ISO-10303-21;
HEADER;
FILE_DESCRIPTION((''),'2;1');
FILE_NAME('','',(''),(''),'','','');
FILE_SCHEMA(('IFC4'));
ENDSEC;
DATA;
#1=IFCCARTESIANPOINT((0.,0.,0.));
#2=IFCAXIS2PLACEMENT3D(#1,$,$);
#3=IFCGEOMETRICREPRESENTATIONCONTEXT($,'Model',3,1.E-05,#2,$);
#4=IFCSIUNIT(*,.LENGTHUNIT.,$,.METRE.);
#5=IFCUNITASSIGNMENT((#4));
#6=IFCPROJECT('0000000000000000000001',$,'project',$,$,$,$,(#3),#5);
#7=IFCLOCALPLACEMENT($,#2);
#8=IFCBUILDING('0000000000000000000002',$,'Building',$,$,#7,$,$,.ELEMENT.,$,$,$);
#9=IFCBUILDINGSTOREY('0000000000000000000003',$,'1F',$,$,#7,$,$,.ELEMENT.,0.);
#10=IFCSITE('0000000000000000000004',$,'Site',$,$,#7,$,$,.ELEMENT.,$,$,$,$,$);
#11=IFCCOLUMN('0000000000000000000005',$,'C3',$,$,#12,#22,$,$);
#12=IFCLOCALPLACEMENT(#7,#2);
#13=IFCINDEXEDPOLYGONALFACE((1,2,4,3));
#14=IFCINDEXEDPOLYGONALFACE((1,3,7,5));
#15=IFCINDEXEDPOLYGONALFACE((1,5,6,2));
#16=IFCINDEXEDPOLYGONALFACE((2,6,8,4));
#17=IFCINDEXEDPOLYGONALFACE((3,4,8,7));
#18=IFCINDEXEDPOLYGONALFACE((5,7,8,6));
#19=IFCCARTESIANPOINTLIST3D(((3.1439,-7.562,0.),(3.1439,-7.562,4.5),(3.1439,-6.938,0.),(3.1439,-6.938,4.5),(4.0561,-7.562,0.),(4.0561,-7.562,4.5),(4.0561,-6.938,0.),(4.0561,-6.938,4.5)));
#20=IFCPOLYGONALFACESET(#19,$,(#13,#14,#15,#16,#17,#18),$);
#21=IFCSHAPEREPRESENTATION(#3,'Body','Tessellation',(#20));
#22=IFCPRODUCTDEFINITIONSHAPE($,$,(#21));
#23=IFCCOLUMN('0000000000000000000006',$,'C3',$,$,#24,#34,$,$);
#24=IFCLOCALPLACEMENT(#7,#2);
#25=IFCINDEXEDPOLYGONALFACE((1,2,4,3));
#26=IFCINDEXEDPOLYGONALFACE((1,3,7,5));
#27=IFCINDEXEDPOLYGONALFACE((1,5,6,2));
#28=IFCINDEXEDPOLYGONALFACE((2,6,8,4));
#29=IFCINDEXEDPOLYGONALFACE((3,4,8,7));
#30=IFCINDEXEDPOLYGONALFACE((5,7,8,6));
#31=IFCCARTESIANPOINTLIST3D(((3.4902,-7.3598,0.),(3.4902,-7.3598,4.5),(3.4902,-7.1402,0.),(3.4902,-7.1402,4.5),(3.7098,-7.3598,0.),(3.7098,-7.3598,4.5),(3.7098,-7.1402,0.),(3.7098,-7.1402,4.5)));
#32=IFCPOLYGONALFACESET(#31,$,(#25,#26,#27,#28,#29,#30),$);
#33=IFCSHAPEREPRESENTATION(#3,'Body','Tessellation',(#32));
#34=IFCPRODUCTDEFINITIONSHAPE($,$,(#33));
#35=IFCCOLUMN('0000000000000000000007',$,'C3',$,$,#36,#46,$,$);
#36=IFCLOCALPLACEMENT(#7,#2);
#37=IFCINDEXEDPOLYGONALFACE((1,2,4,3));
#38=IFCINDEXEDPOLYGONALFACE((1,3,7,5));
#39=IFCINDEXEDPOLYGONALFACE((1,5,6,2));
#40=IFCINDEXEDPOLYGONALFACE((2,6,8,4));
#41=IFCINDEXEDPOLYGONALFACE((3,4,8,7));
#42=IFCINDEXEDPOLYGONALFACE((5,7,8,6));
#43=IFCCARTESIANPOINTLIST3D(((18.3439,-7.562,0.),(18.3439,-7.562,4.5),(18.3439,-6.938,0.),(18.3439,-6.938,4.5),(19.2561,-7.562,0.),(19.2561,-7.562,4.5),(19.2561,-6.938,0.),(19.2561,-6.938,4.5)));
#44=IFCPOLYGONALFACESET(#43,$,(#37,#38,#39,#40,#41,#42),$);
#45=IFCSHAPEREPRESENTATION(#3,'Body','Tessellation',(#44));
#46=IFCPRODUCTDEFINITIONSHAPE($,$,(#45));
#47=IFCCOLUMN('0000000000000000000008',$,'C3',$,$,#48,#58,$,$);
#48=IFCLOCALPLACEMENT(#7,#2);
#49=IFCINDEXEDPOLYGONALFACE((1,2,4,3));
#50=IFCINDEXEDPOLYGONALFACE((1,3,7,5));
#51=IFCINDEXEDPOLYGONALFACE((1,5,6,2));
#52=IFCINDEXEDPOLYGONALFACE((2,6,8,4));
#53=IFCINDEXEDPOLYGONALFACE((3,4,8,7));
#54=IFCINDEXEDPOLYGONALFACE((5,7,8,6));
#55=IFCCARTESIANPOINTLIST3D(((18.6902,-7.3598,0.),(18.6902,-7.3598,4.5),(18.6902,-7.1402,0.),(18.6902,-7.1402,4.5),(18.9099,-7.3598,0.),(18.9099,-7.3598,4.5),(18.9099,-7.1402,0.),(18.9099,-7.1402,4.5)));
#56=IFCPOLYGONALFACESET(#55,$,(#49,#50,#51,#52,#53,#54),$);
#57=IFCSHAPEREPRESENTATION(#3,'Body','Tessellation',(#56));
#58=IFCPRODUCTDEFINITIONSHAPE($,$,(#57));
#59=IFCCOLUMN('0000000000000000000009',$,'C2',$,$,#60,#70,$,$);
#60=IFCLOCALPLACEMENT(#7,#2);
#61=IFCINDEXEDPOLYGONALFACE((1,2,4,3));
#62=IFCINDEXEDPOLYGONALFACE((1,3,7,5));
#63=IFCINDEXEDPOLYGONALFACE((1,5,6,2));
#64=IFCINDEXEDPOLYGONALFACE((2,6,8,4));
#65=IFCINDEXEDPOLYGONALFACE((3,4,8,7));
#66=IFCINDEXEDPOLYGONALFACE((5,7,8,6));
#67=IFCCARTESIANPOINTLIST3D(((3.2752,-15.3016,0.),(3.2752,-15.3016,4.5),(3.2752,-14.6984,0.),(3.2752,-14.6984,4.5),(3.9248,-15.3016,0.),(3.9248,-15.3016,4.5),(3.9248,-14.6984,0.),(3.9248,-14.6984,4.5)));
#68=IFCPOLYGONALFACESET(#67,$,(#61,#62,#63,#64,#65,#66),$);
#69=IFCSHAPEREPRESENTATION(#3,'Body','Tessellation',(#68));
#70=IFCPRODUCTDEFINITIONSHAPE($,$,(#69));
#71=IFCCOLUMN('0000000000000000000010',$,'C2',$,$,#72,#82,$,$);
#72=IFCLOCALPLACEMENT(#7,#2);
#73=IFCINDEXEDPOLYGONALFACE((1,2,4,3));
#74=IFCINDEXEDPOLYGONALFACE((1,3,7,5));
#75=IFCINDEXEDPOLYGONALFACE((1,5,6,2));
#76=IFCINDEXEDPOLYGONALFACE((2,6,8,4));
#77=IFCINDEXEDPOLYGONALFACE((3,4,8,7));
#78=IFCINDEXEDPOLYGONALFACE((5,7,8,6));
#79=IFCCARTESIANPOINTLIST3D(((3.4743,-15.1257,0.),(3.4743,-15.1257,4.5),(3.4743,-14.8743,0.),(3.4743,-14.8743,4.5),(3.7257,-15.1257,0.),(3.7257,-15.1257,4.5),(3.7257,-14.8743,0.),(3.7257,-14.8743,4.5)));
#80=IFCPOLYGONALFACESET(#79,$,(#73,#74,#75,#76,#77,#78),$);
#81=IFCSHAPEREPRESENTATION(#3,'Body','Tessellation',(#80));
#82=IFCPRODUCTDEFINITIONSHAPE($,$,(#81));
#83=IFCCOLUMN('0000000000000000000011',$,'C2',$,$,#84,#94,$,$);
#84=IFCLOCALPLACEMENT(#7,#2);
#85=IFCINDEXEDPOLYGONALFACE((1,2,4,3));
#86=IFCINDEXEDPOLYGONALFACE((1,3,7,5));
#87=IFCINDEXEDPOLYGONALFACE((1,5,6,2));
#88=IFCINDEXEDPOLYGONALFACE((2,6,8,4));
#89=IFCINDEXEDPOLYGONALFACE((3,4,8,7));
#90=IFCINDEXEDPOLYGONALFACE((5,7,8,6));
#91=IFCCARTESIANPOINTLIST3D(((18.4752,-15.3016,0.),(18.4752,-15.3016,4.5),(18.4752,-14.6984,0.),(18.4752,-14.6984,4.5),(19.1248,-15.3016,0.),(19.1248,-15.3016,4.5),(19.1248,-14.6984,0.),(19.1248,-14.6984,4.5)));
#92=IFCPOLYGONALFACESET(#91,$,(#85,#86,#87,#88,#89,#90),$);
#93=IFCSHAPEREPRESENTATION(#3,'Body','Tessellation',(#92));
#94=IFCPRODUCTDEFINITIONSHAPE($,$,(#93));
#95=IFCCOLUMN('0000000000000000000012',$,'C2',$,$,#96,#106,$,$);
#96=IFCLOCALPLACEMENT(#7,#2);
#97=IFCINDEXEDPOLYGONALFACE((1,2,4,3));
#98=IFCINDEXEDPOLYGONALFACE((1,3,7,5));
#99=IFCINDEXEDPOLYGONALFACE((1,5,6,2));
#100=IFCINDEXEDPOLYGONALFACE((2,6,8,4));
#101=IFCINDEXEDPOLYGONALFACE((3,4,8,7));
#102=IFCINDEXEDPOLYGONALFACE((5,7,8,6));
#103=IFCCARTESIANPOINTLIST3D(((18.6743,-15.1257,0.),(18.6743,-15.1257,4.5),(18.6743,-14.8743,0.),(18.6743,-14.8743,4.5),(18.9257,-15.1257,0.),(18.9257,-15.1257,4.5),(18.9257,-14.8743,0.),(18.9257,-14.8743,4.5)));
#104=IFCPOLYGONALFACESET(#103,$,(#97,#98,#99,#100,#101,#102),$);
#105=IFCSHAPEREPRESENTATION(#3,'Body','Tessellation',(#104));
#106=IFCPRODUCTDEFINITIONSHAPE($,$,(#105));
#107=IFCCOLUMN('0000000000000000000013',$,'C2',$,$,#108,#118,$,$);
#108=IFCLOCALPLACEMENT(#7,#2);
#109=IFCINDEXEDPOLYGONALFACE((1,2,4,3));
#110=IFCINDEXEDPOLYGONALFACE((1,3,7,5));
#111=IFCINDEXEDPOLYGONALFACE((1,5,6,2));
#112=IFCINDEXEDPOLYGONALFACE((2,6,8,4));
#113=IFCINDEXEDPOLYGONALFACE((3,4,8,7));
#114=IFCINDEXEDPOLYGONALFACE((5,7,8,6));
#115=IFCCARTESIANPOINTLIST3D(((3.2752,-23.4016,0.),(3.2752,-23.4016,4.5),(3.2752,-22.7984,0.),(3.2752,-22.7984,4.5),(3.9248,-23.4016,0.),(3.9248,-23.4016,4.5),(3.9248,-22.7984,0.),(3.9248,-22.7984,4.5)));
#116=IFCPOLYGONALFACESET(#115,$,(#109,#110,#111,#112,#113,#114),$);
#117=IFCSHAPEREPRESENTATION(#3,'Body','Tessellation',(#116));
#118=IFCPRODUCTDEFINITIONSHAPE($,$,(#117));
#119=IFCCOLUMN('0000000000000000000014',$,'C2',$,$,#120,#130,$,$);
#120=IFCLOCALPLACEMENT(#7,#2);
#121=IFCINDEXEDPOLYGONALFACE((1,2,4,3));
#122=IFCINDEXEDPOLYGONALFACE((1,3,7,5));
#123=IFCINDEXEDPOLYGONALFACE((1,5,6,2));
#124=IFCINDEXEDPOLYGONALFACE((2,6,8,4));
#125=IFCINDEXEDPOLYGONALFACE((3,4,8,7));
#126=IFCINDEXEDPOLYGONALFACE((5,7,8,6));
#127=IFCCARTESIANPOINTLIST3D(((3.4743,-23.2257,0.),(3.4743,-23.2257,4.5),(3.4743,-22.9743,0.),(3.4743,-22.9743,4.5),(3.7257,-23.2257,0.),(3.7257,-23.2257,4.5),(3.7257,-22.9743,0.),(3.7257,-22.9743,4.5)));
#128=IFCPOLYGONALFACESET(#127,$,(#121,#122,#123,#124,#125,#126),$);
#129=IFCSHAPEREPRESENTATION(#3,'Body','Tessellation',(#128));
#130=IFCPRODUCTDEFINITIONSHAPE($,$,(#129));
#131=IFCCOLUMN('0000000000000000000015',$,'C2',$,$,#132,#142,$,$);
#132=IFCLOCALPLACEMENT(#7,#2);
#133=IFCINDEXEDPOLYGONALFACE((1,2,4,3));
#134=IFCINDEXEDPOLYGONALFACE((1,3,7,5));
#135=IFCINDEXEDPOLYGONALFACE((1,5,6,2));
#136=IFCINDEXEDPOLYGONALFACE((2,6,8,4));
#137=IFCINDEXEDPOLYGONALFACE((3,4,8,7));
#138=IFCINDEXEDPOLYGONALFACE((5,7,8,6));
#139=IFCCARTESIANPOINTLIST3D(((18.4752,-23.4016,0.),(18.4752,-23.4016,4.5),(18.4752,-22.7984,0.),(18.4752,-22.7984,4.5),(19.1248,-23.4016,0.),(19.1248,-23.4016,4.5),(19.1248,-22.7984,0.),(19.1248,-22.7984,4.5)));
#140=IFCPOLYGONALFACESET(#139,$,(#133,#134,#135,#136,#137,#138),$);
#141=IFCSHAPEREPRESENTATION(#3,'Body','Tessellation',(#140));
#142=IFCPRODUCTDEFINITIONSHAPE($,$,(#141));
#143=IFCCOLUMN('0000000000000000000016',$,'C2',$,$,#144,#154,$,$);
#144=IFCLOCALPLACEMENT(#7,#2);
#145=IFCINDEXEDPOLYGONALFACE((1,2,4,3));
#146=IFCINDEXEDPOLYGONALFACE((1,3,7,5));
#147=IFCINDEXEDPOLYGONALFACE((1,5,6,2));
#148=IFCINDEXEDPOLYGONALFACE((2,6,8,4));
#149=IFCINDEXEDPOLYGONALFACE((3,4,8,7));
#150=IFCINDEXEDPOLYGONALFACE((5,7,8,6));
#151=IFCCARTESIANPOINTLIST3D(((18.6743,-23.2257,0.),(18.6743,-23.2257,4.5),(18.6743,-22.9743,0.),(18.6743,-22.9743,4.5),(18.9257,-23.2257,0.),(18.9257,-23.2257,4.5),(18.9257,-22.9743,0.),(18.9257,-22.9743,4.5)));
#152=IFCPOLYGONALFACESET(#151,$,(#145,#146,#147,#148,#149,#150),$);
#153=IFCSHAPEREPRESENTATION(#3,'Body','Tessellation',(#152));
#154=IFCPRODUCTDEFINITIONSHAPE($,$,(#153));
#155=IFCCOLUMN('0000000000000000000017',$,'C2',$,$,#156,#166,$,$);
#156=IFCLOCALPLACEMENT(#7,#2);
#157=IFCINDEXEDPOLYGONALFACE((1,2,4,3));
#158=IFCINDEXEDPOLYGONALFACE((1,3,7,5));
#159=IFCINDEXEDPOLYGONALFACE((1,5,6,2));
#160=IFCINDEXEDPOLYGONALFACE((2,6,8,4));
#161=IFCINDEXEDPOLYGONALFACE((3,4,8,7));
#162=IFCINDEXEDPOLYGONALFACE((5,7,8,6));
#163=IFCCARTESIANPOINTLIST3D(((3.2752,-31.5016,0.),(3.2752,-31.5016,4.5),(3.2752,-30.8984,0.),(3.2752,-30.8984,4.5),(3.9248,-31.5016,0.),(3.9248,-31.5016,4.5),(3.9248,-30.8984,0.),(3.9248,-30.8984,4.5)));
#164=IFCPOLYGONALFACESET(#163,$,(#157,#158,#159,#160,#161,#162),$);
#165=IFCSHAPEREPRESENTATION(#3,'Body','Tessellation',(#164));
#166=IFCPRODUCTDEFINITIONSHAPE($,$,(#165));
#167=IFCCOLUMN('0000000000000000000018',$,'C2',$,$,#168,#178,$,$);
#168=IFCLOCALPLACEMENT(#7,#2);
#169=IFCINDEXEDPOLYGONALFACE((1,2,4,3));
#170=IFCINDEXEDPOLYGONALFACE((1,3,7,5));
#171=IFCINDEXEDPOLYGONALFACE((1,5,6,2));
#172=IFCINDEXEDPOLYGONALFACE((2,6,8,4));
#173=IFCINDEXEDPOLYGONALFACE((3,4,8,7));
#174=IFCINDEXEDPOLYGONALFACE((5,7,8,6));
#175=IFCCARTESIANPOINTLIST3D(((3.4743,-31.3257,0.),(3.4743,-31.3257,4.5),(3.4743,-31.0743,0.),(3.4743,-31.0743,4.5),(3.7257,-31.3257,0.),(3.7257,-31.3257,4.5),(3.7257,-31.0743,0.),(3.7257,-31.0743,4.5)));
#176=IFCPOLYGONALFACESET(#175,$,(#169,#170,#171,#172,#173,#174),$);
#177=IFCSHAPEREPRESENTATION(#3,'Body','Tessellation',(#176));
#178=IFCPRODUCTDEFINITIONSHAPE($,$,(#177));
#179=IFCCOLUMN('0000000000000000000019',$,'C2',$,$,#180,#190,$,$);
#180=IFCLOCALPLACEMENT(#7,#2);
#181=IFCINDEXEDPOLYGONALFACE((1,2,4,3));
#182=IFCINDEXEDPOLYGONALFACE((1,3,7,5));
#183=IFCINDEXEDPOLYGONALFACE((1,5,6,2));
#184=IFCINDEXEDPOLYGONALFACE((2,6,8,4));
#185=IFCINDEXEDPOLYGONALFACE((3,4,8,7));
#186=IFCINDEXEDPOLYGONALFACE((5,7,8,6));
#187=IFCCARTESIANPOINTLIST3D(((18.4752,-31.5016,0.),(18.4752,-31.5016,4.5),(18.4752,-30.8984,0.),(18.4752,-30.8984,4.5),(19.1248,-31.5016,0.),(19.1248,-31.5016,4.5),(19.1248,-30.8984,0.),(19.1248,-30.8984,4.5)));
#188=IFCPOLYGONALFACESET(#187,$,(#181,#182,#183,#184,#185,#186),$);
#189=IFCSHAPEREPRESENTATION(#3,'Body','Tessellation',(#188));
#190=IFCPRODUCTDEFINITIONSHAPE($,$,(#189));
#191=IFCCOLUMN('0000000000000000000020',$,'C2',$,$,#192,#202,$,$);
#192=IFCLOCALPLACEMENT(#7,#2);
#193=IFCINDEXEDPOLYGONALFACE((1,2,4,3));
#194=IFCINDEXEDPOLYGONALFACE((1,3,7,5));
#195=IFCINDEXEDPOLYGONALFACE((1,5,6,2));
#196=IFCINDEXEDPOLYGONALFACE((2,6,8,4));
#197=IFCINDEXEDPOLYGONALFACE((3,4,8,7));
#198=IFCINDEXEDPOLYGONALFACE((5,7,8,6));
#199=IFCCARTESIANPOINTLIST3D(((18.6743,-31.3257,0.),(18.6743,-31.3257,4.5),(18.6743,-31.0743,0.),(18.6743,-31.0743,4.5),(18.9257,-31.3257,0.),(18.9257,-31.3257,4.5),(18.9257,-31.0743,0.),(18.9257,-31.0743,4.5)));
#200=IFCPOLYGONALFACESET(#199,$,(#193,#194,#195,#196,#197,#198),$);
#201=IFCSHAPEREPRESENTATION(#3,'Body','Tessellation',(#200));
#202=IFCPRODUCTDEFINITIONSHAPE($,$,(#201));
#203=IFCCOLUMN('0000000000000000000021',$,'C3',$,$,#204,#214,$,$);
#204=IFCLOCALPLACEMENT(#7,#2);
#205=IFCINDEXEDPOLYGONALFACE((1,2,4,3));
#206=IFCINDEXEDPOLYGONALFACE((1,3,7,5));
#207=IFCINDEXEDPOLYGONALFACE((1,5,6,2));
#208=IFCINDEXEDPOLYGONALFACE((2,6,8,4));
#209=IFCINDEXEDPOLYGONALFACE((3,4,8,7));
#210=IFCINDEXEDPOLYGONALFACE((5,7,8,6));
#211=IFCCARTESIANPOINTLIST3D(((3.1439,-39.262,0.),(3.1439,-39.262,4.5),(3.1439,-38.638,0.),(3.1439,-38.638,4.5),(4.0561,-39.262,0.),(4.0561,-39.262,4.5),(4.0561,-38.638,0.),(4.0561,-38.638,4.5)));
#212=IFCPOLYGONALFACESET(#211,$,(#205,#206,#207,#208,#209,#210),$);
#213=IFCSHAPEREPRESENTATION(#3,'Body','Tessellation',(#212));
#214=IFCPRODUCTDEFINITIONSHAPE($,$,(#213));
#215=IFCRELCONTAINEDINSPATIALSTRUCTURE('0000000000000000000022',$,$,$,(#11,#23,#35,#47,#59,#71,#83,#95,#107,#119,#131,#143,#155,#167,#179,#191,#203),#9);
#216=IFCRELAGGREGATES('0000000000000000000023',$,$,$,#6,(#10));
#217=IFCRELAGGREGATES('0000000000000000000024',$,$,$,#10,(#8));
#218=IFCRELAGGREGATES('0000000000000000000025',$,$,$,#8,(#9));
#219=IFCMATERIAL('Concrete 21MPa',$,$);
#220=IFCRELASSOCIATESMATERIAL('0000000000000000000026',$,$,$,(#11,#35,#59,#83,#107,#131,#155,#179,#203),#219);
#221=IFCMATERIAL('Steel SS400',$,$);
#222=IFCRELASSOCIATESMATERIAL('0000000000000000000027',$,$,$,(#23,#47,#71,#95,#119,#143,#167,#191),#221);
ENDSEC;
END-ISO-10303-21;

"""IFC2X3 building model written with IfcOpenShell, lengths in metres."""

from ifc_helpers import new_model, si_unit, frame, origin, origin_2d, place, context, project, spatial, rectangle, extrude, material, element, save


model = new_model("IFC2X3")

# Units and contexts
model_context = context("Model", 3, precision=1e-05, world=origin())
ifc_project = project(units=[si_unit("LENGTHUNIT", "METRE")], contexts=[model_context])

# Site, building, storey
placement = place(None, origin())
site = spatial("IfcSite", under=ifc_project, at=placement, Name="Site", CompositionType="ELEMENT")
building = spatial("IfcBuilding", under=site, at=placement, Name="Building", CompositionType="ELEMENT")
storey = spatial("IfcBuildingStorey", under=building, at=placement, Name="1F", CompositionType="ELEMENT", Elevation=0.0)

# Columns
ifc_material_1 = material(Name="Concrete 21MPa")
column_1_placement = place(None, frame((3.6, -7.25, 0.0)))
element("IfcColumn", 1, at=column_1_placement, inside=storey, material=ifc_material_1, Name="C3", context=model_context, shape_type="SweptSolid", body=[
    extrude(rectangle(XDim=0.9121, YDim=0.6241, at=origin_2d()), origin(), (0.0, 0.0, 1.0), 4.5),
])
ifc_material_2 = material(Name="Steel SS400")
column_2_placement = place(None, frame((3.6, -7.25, 0.0)))
element("IfcColumn", 2, at=column_2_placement, inside=storey, material=ifc_material_2, Name="C3", context=model_context, shape_type="SweptSolid", body=[
    extrude(rectangle(XDim=0.2197, YDim=0.2197, at=origin_2d()), origin(), (0.0, 0.0, 1.0), 4.5),
])
column_3_placement = place(None, frame((18.8, -7.25, 0.0)))
element("IfcColumn", 3, at=column_3_placement, inside=storey, material=ifc_material_1, Name="C3", context=model_context, shape_type="SweptSolid", body=[
    extrude(rectangle(XDim=0.9121, YDim=0.6241, at=origin_2d()), origin(), (0.0, 0.0, 1.0), 4.5),
])
column_4_placement = place(None, frame((18.8, -7.25, 0.0)))
element("IfcColumn", 4, at=column_4_placement, inside=storey, material=ifc_material_2, Name="C3", context=model_context, shape_type="SweptSolid", body=[
    extrude(rectangle(XDim=0.2197, YDim=0.2197, at=origin_2d()), origin(), (0.0, 0.0, 1.0), 4.5),
])
column_5_placement = place(None, frame((3.6, -15.0, 0.0)))
element("IfcColumn", 5, at=column_5_placement, inside=storey, material=ifc_material_1, Name="C2", context=model_context, shape_type="SweptSolid", body=[
    extrude(rectangle(XDim=0.6496, YDim=0.6032, at=origin_2d()), origin(), (0.0, 0.0, 1.0), 4.5),
])
column_6_placement = place(None, frame((3.6, -15.0, 0.0)))
element("IfcColumn", 6, at=column_6_placement, inside=storey, material=ifc_material_2, Name="C2", context=model_context, shape_type="SweptSolid", body=[
    extrude(rectangle(XDim=0.2513, YDim=0.2513, at=origin_2d()), origin(), (0.0, 0.0, 1.0), 4.5),
])
column_7_placement = place(None, frame((18.8, -15.0, 0.0)))
element("IfcColumn", 7, at=column_7_placement, inside=storey, material=ifc_material_1, Name="C2", context=model_context, shape_type="SweptSolid", body=[
    extrude(rectangle(XDim=0.6496, YDim=0.6032, at=origin_2d()), origin(), (0.0, 0.0, 1.0), 4.5),
])
column_8_placement = place(None, frame((18.8, -15.0, 0.0)))
element("IfcColumn", 8, at=column_8_placement, inside=storey, material=ifc_material_2, Name="C2", context=model_context, shape_type="SweptSolid", body=[
    extrude(rectangle(XDim=0.2513, YDim=0.2513, at=origin_2d()), origin(), (0.0, 0.0, 1.0), 4.5),
])
column_9_placement = place(None, frame((3.6, -23.1, 0.0)))
element("IfcColumn", 9, at=column_9_placement, inside=storey, material=ifc_material_1, Name="C2", context=model_context, shape_type="SweptSolid", body=[
    extrude(rectangle(XDim=0.6496, YDim=0.6032, at=origin_2d()), origin(), (0.0, 0.0, 1.0), 4.5),
])
column_10_placement = place(None, frame((3.6, -23.1, 0.0)))
element("IfcColumn", 10, at=column_10_placement, inside=storey, material=ifc_material_2, Name="C2", context=model_context, shape_type="SweptSolid", body=[
    extrude(rectangle(XDim=0.2513, YDim=0.2513, at=origin_2d()), origin(), (0.0, 0.0, 1.0), 4.5),
])
column_11_placement = place(None, frame((18.8, -23.1, 0.0)))
element("IfcColumn", 11, at=column_11_placement, inside=storey, material=ifc_material_1, Name="C2", context=model_context, shape_type="SweptSolid", body=[
    extrude(rectangle(XDim=0.6496, YDim=0.6032, at=origin_2d()), origin(), (0.0, 0.0, 1.0), 4.5),
])
column_12_placement = place(None, frame((18.8, -23.1, 0.0)))
element("IfcColumn", 12, at=column_12_placement, inside=storey, material=ifc_material_2, Name="C2", context=model_context, shape_type="SweptSolid", body=[
    extrude(rectangle(XDim=0.2513, YDim=0.2513, at=origin_2d()), origin(), (0.0, 0.0, 1.0), 4.5),
])
column_13_placement = place(None, frame((3.6, -31.2, 0.0)))
element("IfcColumn", 13, at=column_13_placement, inside=storey, material=ifc_material_1, Name="C2", context=model_context, shape_type="SweptSolid", body=[
    extrude(rectangle(XDim=0.6496, YDim=0.6032, at=origin_2d()), origin(), (0.0, 0.0, 1.0), 4.5),
])
column_14_placement = place(None, frame((3.6, -31.2, 0.0)))
element("IfcColumn", 14, at=column_14_placement, inside=storey, material=ifc_material_2, Name="C2", context=model_context, shape_type="SweptSolid", body=[
    extrude(rectangle(XDim=0.2513, YDim=0.2513, at=origin_2d()), origin(), (0.0, 0.0, 1.0), 4.5),
])
column_15_placement = place(None, frame((18.8, -31.2, 0.0)))
element("IfcColumn", 15, at=column_15_placement, inside=storey, material=ifc_material_1, Name="C2", context=model_context, shape_type="SweptSolid", body=[
    extrude(rectangle(XDim=0.6496, YDim=0.6032, at=origin_2d()), origin(), (0.0, 0.0, 1.0), 4.5),
])
column_16_placement = place(None, frame((18.8, -31.2, 0.0)))
element("IfcColumn", 16, at=column_16_placement, inside=storey, material=ifc_material_2, Name="C2", context=model_context, shape_type="SweptSolid", body=[
    extrude(rectangle(XDim=0.2513, YDim=0.2513, at=origin_2d()), origin(), (0.0, 0.0, 1.0), 4.5),
])
column_17_placement = place(None, frame((3.6, -38.95, 0.0)))
element("IfcColumn", 17, at=column_17_placement, inside=storey, material=ifc_material_1, Name="C3", context=model_context, shape_type="SweptSolid", body=[
    extrude(rectangle(XDim=0.9121, YDim=0.6241, at=origin_2d()), origin(), (0.0, 0.0, 1.0), 4.5),
])

save(model, "model.ifc")
